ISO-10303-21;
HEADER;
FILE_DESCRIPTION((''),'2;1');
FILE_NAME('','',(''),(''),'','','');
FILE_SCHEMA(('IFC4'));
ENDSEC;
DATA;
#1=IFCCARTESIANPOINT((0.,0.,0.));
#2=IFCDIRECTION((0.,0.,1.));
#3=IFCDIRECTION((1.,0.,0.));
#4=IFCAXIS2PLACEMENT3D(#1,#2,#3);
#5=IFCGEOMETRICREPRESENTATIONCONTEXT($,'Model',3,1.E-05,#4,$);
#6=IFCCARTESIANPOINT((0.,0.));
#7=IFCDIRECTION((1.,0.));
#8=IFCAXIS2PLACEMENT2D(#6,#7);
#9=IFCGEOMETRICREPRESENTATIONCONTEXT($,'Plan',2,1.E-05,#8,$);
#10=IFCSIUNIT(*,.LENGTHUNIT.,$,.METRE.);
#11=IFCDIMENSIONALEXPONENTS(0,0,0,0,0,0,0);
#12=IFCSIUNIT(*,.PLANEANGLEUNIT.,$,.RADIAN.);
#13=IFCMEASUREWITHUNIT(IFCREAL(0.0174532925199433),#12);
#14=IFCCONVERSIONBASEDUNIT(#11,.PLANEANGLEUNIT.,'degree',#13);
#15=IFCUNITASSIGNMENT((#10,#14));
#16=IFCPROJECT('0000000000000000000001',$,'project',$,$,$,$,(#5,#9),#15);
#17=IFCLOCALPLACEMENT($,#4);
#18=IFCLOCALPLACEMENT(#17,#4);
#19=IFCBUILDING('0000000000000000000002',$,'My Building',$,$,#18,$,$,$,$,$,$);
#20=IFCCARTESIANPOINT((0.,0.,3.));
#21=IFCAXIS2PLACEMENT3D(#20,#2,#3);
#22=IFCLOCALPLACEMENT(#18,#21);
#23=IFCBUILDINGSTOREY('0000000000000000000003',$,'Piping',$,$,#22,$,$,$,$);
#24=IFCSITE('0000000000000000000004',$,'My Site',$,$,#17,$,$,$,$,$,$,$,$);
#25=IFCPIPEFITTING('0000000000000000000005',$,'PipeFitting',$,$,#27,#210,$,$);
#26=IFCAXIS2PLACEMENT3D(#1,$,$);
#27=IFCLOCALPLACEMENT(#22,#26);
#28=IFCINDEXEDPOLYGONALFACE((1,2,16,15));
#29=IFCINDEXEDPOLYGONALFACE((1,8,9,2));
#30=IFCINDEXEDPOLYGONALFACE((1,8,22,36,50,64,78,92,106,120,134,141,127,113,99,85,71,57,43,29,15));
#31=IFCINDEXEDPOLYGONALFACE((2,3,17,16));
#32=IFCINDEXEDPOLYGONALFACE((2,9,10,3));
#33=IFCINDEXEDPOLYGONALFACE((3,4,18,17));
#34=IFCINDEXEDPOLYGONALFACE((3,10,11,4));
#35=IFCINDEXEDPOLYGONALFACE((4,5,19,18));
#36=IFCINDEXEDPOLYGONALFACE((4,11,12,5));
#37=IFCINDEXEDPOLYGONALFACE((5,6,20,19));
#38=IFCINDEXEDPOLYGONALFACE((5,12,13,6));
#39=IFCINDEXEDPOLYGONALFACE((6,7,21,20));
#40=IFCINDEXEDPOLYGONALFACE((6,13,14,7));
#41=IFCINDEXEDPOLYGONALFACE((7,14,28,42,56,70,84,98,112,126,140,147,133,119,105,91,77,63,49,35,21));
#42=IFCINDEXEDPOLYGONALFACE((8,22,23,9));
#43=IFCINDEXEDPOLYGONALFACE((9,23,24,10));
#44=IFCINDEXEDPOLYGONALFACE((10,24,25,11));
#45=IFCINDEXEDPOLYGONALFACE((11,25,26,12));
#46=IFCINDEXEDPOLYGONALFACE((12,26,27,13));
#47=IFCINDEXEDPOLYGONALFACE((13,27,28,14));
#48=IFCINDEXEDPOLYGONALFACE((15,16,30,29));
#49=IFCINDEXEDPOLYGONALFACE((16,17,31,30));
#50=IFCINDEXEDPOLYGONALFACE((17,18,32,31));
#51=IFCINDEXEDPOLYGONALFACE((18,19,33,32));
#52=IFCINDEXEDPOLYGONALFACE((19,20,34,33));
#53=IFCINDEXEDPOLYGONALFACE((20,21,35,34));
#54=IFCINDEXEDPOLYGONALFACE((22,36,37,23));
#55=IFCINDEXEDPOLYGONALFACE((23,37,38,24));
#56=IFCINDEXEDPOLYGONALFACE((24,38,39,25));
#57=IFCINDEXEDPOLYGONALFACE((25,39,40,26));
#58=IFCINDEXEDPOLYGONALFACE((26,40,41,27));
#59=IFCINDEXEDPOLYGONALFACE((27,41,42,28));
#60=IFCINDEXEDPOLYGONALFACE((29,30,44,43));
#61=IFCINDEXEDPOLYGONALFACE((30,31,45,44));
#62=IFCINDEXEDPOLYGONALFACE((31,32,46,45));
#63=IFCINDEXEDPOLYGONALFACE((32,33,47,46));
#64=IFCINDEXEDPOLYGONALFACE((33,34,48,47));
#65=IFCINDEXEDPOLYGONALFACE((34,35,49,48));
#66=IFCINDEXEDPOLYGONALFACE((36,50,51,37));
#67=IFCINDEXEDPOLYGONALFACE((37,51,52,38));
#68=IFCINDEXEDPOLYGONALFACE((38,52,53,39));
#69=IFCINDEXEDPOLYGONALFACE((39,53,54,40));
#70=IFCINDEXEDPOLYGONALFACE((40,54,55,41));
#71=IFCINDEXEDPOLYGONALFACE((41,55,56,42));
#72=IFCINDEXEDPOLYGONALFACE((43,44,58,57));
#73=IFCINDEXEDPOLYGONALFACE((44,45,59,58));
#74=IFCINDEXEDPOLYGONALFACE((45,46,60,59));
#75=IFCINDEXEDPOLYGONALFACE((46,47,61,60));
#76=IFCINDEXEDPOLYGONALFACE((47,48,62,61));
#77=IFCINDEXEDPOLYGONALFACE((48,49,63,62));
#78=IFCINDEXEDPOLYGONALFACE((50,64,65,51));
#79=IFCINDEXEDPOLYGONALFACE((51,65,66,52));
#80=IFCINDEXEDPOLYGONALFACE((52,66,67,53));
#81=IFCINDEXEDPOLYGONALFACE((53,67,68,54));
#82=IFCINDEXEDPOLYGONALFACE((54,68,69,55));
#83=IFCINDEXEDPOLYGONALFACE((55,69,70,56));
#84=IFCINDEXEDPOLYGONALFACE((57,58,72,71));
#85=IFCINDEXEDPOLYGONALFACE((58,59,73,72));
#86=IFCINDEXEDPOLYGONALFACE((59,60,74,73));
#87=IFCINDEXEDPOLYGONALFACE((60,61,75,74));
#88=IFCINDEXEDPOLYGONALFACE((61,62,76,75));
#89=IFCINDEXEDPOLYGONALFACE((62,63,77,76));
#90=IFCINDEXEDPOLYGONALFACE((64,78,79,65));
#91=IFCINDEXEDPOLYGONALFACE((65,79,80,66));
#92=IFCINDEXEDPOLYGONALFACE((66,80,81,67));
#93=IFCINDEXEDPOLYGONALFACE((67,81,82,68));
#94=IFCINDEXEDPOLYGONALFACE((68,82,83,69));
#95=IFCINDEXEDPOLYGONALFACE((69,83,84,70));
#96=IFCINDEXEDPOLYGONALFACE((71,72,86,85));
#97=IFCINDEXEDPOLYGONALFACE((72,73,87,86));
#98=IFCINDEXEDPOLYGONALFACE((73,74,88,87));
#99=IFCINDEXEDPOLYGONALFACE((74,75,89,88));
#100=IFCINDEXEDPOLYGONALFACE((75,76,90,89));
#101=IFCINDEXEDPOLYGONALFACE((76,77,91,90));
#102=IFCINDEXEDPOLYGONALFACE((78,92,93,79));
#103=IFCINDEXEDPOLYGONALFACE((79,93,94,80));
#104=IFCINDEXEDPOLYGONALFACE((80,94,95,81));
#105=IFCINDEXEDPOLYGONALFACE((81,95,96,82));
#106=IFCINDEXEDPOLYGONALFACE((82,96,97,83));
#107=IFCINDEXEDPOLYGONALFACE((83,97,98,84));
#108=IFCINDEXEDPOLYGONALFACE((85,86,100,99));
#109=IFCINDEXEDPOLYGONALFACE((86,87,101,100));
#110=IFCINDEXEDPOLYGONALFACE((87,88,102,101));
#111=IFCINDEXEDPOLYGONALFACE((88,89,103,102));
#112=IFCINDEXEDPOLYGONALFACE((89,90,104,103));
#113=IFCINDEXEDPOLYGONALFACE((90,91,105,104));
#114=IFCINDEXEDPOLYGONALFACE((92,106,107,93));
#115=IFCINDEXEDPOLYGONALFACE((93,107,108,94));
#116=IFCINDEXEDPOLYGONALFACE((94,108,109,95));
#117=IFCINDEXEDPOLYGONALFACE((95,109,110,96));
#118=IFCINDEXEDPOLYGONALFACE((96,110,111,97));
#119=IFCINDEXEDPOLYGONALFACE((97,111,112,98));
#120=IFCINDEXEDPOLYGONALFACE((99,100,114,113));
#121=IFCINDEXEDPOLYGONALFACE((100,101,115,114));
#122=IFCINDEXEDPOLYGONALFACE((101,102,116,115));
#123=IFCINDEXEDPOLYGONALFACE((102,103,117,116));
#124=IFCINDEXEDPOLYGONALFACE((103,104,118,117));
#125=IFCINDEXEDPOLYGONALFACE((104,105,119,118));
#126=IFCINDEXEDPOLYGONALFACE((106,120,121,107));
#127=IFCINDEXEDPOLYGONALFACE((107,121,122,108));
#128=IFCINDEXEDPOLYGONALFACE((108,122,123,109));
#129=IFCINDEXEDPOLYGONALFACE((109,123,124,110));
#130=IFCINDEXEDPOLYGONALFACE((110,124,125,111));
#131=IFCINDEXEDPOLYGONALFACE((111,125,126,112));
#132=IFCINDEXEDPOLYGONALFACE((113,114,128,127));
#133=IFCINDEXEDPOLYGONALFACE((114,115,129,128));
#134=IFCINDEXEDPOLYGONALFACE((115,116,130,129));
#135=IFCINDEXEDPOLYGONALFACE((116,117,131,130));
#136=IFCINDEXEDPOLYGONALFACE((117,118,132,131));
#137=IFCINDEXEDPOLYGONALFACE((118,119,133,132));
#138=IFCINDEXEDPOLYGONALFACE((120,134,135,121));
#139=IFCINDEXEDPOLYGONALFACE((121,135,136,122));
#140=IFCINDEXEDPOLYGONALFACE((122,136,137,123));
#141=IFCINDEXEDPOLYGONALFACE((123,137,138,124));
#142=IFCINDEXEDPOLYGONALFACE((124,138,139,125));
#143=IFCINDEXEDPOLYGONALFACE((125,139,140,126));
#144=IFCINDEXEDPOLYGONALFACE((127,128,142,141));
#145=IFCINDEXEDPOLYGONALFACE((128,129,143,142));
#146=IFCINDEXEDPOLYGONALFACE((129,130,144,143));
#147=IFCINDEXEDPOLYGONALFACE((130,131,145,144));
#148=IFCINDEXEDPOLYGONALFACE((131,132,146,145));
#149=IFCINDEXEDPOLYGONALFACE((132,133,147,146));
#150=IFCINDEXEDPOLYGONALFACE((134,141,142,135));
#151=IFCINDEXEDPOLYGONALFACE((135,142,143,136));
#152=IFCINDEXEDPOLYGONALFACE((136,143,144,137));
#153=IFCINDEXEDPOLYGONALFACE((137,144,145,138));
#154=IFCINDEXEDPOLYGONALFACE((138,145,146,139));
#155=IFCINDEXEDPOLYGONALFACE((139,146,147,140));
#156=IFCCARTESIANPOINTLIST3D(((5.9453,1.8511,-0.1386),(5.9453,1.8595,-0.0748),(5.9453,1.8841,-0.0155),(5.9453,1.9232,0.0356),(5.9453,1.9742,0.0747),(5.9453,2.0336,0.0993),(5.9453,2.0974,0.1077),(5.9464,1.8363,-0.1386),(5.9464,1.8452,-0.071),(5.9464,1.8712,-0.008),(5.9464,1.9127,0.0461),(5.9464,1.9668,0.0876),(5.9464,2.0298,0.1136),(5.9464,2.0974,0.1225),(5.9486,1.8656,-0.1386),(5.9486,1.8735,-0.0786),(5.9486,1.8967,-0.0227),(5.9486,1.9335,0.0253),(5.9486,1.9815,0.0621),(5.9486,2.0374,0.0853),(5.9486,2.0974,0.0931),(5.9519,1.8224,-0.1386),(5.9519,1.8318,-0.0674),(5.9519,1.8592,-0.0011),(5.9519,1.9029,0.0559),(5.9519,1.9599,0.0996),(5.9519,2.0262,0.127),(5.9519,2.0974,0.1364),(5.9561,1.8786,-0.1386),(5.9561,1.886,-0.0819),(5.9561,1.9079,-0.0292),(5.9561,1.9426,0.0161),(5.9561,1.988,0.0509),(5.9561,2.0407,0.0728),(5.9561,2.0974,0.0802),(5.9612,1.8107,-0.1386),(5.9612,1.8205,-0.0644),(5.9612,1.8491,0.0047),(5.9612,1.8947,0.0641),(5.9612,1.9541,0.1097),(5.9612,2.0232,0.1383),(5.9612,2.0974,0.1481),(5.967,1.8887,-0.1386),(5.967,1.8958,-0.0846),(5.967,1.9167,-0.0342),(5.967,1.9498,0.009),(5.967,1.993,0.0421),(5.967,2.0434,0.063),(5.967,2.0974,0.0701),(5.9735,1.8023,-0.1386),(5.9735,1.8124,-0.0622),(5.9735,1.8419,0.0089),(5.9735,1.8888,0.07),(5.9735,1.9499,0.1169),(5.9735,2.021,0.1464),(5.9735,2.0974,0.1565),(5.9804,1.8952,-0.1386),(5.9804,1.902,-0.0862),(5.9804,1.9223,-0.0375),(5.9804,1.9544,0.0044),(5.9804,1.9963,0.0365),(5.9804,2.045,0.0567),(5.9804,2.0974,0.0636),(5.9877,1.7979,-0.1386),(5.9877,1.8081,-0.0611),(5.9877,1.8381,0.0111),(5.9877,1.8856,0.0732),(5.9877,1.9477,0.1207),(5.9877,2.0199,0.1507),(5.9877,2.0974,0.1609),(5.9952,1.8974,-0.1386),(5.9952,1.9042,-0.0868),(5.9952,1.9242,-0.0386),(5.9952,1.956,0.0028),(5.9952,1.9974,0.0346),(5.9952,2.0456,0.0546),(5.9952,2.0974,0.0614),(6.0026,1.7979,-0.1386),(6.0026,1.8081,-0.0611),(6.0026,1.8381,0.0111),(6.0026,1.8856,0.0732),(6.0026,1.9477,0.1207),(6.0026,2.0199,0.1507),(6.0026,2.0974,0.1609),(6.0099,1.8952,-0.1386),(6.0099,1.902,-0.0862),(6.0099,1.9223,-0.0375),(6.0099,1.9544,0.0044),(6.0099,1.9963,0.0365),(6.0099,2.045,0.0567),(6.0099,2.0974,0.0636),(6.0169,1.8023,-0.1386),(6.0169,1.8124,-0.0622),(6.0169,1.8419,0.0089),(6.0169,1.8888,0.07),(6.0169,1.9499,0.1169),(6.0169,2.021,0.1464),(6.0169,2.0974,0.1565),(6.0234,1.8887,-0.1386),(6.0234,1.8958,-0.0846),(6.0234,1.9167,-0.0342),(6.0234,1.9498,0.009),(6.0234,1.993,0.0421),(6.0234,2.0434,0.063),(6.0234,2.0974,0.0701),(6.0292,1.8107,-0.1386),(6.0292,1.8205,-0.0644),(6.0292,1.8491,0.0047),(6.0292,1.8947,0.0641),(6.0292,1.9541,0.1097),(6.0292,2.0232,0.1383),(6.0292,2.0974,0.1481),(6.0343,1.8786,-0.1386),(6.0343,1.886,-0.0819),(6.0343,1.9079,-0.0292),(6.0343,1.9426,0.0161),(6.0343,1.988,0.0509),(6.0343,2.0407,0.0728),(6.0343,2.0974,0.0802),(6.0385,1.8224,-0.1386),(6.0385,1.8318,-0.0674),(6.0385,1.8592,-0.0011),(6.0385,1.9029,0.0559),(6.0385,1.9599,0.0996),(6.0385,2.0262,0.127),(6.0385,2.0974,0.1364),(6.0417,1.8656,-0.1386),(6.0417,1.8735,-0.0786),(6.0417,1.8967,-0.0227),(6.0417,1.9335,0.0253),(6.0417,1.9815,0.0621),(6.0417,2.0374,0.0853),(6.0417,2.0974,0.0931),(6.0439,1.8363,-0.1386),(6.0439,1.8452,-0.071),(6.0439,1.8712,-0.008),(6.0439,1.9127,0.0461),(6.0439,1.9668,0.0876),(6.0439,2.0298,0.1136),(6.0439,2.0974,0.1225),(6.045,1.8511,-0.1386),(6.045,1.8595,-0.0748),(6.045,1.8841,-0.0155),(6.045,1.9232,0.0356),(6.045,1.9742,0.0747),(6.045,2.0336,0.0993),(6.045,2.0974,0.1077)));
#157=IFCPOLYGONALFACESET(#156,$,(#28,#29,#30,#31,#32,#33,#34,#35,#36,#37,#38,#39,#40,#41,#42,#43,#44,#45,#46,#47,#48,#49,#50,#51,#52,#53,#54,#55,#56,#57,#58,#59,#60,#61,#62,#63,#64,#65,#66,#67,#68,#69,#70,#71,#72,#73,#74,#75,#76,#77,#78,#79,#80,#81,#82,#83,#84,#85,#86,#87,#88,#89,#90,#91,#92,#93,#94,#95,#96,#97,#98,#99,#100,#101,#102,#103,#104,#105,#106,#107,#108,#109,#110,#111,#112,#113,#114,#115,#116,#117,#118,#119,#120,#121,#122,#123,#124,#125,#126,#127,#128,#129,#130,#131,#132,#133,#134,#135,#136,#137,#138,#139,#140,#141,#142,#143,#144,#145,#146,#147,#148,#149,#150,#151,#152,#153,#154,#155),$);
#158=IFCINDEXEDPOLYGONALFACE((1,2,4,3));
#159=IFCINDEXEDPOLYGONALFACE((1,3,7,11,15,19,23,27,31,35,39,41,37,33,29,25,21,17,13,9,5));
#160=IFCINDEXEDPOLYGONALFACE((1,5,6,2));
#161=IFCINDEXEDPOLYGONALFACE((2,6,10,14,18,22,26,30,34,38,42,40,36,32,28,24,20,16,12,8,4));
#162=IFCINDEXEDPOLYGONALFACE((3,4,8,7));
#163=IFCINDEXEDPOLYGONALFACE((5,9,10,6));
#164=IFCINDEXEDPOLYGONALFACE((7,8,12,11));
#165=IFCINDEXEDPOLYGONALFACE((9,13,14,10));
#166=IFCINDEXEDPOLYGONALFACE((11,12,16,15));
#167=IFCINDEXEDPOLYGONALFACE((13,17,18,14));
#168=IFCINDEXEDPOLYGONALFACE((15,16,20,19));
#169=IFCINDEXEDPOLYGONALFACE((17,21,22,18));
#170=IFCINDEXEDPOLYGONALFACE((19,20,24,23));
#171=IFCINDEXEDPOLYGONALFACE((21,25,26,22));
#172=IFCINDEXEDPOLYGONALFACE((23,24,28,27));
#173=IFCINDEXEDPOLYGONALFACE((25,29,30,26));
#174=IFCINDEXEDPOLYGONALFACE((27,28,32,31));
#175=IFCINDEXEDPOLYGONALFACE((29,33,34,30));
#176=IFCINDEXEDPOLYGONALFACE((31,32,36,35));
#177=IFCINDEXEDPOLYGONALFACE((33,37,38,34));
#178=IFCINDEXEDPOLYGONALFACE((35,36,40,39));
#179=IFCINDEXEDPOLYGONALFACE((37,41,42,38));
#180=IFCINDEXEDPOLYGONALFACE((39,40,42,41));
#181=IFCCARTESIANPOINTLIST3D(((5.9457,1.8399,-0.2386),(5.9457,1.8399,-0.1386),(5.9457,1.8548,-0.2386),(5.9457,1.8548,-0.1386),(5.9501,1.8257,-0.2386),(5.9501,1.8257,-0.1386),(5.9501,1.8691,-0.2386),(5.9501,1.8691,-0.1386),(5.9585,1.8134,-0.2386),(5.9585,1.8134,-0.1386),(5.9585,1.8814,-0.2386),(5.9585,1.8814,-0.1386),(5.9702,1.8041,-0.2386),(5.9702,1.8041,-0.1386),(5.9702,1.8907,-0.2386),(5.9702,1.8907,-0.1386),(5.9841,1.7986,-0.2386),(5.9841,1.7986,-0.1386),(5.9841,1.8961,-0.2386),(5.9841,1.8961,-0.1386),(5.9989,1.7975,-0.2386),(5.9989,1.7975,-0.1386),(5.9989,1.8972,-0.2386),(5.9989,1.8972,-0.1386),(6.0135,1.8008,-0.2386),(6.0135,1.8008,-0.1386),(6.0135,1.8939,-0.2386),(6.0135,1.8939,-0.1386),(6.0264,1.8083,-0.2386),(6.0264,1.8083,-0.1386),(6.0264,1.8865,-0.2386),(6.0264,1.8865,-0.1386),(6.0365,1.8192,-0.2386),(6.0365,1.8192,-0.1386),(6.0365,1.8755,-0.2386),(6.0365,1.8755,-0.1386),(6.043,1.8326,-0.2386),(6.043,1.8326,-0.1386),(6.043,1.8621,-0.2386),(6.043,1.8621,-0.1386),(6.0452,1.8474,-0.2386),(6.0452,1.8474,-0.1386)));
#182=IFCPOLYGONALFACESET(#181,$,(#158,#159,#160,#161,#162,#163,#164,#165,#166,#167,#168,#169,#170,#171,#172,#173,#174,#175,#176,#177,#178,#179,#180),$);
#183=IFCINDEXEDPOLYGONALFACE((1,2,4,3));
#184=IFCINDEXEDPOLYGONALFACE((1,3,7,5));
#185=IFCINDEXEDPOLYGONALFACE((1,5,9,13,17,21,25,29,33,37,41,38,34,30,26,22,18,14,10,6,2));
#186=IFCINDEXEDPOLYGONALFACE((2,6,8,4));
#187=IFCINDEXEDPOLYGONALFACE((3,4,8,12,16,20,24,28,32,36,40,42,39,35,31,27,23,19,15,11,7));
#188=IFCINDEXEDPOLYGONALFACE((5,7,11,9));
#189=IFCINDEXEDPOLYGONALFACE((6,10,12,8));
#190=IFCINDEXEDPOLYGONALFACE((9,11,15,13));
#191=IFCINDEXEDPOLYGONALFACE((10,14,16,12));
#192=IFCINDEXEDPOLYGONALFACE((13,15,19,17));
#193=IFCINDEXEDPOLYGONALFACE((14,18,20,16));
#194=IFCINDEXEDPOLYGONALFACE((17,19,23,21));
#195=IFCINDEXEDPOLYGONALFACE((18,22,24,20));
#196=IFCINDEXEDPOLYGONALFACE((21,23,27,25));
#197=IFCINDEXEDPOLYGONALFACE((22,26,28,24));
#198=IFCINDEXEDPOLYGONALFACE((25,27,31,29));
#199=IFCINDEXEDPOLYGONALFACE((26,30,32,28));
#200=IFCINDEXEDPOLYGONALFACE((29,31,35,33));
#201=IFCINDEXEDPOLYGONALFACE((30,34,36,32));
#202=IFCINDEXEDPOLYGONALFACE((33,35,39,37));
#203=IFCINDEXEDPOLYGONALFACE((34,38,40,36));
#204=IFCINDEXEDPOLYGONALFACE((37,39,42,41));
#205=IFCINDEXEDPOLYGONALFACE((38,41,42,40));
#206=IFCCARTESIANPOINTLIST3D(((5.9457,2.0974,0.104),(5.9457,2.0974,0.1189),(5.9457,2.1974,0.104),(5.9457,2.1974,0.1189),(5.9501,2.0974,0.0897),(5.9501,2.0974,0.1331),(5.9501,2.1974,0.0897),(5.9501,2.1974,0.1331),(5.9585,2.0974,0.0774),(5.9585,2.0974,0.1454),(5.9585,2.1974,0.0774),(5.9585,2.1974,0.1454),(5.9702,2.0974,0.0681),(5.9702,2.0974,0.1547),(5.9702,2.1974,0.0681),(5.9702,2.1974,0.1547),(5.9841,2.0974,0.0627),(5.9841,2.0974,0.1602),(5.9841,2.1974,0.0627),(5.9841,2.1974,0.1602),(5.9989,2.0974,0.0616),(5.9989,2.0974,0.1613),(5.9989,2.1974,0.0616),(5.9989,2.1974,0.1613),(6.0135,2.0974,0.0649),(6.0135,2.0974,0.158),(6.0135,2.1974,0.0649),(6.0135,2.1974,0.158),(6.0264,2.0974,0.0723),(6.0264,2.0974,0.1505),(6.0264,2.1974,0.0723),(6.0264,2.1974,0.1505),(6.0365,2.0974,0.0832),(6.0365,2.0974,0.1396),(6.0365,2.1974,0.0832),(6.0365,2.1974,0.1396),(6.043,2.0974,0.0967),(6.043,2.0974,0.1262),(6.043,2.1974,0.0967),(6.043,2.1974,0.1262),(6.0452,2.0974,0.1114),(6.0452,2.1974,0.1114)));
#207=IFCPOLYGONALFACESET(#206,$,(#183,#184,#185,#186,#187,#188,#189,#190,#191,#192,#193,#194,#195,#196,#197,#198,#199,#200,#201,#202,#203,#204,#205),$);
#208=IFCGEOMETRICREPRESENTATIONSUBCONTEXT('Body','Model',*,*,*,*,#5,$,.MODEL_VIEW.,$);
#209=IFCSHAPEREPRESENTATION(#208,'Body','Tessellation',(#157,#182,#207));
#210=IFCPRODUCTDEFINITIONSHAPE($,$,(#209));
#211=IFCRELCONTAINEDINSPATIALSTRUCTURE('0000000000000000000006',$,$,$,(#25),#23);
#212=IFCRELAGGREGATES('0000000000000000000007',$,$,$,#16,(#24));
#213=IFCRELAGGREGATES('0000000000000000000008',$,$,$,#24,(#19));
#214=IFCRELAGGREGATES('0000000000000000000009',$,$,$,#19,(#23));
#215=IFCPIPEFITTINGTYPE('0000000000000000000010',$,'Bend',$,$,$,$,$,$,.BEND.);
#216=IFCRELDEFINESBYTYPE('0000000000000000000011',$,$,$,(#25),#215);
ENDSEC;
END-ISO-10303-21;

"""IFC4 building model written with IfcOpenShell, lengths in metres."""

from ifc_helpers import new_model, entity, si_unit, converted_unit, frame, origin_with_axes, origin_2d_with_axis, place, context, subcontext, project, spatial, circle, extrude, source, transform, mapped, type_object, type_shapes, element, save


model = new_model("IFC4")

# Units and contexts
model_context = context("Model", 3, precision=1e-05, world=origin_with_axes())
plan_context = context("Plan", 2, precision=1e-05, world=origin_2d_with_axis())
body_context = subcontext(model_context, "Body", "Model", "MODEL_VIEW")
ifc_project = project(units=[si_unit("LENGTHUNIT", "METRE"), converted_unit("PLANEANGLEUNIT", "degree", entity("IfcReal", 0.0174532925199433), si_unit("PLANEANGLEUNIT", "RADIAN"), dimensions=[0, 0, 0, 0, 0, 0, 0])], contexts=[model_context, plan_context])

# Site, building, storey
site_placement = place(None, origin_with_axes())
site = spatial("IfcSite", under=ifc_project, at=site_placement, Name="My Site")
building_placement = place(site_placement, origin_with_axes())
building = spatial("IfcBuilding", under=site, at=building_placement, Name="My Building")
storey_placement = place(building_placement, frame((0.0, 0.0, 3.0), z_axis=(0.0, 0.0, 1.0), x_axis=(1.0, 0.0, 0.0)))
storey = spatial("IfcBuildingStorey", under=building, at=storey_placement, Name="Piping")

# Pipe fitting
pipe_fitting_type_1 = type_object("IfcPipeFittingType", Name="Bend", PredefinedType="BEND")
shared_shape = source(origin_with_axes(), body_context, "Body", "SolidModel", [
    entity("IfcSweptDiskSolid", entity("IfcIndexedPolyCurve", entity("IfcCartesianPointList3D", [[0.0, 0.0, -0.1], [0.0, -0.0732, -0.2768], [0.0, -0.25, -0.35]]), [entity("IfcArcIndex", [1, 2, 3])]), 0.05),
    extrude(circle(Radius=0.05), origin_with_axes(), (0.0, 0.0, -1.0), 0.1),
    extrude(circle(Radius=0.05), frame((0.0, -0.25, -0.35), z_axis=(0.0, -1.0, 0.0), x_axis=(1.0, 0.0, 0.0)), (0.0, 0.0, 1.0), 0.1),
])
type_shapes(pipe_fitting_type_1, [shared_shape])
for number, where, z_axis, x_axis, name in (
    (1, (5.9952, 1.8474, -0.2386), (0.0, 0.0, -1.0), (1.0, 0.0, 0.0), "PipeFitting"),
):
    element("IfcPipeFitting", number, at=place(storey_placement, frame(where, z_axis=z_axis, x_axis=x_axis)), inside=storey, type_object=pipe_fitting_type_1, Name=name, context=body_context, shape_type="MappedRepresentation", body=[
        mapped(shared_shape, transform((0.0, 0.0, 0.0), x_axis=(1.0, 0.0, 0.0), y_axis=(0.0, 1.0, 0.0), z_axis=(0.0, 0.0, 1.0), scale=1.0)),
    ])

save(model, "model.ifc")
